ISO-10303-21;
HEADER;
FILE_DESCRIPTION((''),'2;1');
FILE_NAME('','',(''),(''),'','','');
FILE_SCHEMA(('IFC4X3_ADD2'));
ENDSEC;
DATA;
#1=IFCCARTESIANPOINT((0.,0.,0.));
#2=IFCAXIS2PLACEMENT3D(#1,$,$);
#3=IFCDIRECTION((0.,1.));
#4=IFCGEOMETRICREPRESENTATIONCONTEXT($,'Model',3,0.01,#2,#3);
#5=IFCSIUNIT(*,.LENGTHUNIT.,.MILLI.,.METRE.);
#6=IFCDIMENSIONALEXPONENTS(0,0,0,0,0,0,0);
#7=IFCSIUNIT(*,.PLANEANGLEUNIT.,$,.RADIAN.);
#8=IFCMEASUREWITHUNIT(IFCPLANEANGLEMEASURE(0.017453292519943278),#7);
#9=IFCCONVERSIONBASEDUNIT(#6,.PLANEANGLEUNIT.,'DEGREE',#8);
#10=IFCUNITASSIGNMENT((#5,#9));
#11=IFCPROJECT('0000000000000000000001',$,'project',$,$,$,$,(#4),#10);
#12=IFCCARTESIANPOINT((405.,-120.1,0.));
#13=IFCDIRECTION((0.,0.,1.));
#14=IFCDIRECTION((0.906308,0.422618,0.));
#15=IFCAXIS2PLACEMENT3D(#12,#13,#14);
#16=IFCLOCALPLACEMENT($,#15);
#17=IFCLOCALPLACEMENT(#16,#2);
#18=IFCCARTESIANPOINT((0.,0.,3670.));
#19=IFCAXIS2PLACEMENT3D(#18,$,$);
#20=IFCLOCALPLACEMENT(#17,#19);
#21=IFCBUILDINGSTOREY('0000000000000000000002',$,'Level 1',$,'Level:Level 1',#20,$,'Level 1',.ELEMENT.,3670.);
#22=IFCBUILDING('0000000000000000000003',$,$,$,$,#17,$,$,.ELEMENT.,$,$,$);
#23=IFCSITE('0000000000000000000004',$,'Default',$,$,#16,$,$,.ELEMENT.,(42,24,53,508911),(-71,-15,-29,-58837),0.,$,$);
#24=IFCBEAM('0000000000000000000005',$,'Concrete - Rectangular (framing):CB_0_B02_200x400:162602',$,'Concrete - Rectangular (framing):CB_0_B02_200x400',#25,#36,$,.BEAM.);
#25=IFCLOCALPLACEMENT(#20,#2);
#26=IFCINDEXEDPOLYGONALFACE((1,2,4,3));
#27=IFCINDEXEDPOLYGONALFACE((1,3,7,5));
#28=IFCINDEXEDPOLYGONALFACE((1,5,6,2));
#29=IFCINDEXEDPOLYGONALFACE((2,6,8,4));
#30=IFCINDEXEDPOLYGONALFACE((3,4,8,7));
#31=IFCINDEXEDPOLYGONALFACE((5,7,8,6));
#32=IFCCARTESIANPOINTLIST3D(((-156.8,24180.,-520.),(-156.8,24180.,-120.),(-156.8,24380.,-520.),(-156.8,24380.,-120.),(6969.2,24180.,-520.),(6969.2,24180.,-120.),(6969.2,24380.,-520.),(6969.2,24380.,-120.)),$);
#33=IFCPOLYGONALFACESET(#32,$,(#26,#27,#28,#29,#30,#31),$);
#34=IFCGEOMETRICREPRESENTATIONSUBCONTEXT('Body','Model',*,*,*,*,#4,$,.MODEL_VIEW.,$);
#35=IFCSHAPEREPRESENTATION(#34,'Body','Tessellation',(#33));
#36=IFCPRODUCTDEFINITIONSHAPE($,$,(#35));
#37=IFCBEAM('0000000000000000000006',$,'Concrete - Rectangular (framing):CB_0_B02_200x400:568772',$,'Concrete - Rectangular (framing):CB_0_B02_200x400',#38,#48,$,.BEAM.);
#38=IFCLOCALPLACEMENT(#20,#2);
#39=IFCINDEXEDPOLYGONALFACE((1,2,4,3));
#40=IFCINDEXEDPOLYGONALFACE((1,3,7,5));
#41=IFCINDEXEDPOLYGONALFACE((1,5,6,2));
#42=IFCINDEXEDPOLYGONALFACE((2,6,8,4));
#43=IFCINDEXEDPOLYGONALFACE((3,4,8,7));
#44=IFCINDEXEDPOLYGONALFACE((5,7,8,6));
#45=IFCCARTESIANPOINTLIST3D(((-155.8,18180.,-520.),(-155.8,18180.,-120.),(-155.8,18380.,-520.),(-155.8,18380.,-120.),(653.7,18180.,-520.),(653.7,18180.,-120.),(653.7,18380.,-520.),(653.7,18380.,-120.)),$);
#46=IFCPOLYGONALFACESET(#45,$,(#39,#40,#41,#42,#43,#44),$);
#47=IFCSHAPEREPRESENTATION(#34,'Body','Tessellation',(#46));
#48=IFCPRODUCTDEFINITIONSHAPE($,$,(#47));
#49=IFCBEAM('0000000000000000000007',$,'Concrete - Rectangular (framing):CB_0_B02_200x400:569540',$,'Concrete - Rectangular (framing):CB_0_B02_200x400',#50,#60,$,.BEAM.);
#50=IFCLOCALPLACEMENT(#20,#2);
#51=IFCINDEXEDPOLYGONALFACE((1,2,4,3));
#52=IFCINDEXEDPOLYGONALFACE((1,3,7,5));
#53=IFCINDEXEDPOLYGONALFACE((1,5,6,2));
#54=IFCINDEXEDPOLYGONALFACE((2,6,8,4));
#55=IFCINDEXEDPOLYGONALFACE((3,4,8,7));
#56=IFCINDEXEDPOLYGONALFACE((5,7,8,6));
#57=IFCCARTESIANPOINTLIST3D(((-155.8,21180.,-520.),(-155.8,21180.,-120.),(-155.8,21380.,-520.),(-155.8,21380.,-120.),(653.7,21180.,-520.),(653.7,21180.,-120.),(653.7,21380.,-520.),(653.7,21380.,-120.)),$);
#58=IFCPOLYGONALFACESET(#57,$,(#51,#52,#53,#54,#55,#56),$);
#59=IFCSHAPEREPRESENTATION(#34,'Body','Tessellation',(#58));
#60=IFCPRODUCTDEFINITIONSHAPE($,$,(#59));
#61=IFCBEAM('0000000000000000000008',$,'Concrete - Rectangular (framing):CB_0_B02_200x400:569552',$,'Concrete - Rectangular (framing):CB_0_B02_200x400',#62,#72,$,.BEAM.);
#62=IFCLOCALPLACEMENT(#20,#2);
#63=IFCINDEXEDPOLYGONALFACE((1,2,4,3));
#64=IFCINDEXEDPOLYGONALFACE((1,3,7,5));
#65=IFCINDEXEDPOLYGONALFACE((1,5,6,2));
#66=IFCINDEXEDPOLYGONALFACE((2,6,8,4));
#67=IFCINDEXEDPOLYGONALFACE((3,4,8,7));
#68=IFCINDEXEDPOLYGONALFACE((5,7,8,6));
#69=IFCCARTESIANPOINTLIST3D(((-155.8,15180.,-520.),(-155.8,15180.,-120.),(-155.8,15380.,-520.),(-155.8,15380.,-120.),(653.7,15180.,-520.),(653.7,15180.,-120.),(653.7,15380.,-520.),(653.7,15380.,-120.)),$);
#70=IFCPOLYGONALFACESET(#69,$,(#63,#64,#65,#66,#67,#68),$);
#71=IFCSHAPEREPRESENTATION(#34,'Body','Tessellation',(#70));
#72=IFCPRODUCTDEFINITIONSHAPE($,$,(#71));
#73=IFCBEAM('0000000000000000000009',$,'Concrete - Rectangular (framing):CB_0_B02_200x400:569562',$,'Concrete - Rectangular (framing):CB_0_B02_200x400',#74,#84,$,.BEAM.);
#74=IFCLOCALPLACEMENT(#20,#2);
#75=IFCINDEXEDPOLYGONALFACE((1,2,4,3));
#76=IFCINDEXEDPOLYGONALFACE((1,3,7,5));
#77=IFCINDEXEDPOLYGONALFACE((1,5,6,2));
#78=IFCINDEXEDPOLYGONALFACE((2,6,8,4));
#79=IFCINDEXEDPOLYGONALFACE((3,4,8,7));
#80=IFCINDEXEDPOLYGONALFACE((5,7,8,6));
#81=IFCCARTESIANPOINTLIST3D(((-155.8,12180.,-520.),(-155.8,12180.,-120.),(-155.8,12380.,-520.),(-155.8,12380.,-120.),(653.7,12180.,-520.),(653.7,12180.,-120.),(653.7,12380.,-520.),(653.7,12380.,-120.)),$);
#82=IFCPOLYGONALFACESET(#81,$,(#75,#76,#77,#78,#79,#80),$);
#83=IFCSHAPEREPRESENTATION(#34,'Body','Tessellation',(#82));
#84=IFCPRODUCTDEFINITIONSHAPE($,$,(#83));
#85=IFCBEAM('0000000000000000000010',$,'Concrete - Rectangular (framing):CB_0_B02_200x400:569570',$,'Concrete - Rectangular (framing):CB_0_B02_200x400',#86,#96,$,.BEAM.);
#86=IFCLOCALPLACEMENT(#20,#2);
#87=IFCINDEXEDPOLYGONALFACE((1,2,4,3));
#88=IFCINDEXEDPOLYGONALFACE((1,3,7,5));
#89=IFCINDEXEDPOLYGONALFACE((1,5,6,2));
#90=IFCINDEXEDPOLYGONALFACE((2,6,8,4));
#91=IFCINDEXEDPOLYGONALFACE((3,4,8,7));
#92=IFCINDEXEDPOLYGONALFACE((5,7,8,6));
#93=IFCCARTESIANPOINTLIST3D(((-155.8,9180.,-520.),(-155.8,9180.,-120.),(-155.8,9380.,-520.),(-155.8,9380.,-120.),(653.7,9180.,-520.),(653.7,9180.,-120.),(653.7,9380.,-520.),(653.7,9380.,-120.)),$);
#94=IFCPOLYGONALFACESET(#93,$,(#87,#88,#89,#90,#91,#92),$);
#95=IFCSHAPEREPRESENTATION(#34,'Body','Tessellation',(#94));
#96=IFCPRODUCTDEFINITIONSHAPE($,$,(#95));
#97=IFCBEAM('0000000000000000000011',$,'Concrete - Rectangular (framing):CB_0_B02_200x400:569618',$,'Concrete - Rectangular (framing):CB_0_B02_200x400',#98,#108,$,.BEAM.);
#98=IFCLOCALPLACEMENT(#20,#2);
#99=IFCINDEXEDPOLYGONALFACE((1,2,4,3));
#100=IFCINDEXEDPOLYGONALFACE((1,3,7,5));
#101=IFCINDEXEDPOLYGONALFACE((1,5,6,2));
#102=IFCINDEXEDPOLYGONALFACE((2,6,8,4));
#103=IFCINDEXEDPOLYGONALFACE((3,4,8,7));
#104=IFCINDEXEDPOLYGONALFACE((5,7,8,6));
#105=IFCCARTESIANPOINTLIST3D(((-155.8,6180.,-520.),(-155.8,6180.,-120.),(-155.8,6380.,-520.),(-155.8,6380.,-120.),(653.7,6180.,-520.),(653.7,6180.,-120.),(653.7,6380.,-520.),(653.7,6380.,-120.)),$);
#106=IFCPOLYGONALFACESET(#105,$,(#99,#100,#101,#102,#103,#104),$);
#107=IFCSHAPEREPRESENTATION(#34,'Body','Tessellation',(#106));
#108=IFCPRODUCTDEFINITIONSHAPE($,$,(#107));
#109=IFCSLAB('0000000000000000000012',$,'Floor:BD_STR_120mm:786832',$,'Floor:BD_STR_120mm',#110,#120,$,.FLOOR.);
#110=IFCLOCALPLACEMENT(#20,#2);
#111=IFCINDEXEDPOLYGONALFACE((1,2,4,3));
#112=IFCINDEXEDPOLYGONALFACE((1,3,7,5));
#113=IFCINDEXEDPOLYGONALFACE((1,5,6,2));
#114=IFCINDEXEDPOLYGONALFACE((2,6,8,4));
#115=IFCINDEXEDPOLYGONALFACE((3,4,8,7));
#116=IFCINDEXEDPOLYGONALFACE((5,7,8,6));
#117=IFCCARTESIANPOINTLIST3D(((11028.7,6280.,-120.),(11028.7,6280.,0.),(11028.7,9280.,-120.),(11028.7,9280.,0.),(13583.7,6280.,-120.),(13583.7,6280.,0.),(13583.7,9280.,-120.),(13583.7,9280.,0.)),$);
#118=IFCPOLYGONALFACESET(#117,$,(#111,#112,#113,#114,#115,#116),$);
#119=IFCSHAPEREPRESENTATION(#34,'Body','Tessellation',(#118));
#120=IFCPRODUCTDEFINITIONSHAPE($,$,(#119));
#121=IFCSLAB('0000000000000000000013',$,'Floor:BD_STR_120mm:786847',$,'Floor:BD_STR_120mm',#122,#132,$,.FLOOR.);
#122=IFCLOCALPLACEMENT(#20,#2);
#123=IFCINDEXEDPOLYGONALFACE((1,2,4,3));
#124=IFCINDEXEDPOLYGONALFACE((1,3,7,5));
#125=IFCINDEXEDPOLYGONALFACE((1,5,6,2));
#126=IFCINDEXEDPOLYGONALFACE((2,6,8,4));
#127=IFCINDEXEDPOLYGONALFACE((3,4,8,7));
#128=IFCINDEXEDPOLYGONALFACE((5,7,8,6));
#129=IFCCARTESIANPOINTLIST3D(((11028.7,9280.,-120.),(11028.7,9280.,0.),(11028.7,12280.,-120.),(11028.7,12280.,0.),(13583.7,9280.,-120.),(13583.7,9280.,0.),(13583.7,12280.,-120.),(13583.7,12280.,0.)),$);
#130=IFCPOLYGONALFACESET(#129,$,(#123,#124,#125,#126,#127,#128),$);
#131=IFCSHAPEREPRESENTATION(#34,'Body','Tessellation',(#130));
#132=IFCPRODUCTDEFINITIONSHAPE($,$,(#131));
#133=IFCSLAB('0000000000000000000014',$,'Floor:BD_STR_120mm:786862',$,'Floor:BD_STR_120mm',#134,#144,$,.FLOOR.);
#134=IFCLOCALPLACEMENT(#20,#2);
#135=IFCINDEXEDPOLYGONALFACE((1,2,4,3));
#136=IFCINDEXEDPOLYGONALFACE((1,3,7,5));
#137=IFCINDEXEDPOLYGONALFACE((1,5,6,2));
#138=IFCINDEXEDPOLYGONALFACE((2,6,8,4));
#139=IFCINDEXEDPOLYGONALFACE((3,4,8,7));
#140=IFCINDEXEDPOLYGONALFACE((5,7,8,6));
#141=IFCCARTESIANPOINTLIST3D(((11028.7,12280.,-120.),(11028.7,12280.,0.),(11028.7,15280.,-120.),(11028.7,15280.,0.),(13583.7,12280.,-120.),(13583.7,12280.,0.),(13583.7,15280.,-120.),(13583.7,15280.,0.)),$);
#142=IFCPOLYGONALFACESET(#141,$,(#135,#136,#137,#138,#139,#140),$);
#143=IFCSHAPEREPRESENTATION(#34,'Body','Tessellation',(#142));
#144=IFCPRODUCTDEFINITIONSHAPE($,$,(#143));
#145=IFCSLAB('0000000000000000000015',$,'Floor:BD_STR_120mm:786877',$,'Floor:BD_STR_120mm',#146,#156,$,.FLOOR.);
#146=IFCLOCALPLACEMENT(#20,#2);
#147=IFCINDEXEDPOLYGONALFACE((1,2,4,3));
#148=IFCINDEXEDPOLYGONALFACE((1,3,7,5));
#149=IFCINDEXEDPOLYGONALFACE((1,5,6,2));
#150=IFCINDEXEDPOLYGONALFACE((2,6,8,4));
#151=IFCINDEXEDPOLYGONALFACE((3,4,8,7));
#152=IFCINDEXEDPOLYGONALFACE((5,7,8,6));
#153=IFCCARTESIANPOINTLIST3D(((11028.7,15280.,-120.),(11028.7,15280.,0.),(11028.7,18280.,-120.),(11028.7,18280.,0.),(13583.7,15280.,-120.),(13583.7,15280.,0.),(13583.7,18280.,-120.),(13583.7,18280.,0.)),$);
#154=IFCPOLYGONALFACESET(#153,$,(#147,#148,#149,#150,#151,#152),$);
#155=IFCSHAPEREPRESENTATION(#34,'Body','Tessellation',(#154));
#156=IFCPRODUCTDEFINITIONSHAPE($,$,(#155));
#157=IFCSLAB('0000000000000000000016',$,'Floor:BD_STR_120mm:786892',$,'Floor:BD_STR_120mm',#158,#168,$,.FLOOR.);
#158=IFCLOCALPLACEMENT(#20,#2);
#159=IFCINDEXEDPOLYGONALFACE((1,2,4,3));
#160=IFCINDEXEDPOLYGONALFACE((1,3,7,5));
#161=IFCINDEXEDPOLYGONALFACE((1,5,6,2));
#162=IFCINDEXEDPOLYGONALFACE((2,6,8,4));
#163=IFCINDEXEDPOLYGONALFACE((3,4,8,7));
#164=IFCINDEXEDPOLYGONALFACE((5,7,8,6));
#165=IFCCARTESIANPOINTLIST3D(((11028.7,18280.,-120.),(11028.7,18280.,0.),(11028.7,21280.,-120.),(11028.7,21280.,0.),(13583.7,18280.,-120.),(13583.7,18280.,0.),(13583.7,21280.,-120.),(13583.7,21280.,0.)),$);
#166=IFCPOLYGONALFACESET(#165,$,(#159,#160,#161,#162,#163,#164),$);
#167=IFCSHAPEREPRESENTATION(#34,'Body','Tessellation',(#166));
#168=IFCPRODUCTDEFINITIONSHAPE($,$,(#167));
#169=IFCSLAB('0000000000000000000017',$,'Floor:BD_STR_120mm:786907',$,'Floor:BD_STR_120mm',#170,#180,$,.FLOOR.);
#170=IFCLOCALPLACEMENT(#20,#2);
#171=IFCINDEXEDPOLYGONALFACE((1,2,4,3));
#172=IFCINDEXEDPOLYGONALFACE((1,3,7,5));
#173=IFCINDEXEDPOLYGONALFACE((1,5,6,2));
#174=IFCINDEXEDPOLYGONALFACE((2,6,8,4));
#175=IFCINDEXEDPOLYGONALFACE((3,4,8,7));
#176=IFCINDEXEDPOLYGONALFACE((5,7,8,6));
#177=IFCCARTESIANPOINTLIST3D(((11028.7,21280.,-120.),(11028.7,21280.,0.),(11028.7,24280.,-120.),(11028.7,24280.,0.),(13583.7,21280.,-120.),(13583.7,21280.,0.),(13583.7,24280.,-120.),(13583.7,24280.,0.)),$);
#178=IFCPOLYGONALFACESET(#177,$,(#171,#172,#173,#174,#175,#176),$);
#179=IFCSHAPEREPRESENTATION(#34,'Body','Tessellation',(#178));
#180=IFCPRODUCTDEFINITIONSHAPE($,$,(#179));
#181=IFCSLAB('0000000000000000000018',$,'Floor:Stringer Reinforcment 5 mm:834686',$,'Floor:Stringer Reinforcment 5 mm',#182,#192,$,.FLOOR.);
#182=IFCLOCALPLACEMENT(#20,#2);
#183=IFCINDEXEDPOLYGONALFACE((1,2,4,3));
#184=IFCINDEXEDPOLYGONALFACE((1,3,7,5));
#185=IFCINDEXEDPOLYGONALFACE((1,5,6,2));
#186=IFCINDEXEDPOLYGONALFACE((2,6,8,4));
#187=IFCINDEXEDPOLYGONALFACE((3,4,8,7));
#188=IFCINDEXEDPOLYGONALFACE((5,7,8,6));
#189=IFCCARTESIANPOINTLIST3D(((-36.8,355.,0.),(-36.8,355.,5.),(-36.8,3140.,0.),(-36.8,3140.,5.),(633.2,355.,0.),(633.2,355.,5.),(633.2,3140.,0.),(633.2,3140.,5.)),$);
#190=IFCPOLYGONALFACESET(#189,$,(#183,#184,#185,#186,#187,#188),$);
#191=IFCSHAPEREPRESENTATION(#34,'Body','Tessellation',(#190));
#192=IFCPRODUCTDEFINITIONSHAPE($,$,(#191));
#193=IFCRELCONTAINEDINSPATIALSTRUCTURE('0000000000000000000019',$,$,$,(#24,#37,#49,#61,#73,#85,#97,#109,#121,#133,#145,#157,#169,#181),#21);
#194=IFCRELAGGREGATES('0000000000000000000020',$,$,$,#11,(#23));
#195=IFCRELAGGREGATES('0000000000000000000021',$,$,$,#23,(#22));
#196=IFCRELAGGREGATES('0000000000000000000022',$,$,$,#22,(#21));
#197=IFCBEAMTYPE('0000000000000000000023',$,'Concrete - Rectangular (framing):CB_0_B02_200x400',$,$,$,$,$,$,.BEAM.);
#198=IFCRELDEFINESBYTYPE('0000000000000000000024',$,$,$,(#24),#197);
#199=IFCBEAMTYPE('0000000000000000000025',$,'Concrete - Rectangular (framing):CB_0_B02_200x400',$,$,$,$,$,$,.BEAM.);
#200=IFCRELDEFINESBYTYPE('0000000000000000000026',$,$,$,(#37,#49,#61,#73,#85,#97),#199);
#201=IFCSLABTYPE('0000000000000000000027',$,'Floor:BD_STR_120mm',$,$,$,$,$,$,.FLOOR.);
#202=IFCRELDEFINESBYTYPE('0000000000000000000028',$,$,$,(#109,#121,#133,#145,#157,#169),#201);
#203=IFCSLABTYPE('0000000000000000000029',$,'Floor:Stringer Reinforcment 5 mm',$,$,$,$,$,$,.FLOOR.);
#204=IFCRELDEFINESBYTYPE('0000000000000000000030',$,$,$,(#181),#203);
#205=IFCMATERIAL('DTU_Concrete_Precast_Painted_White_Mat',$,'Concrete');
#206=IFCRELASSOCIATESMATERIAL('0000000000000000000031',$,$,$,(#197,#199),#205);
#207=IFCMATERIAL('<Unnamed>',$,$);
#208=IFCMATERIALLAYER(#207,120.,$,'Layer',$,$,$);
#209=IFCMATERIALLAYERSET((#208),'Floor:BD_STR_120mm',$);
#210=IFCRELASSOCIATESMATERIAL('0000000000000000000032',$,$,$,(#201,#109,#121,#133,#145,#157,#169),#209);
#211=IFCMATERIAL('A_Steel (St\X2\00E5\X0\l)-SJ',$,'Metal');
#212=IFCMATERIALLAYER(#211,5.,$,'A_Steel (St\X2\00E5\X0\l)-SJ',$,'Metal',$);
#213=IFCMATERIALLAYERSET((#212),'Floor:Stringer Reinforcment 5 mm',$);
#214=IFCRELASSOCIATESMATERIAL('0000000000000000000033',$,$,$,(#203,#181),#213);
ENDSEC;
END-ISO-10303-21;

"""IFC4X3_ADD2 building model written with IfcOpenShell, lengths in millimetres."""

from ifc_helpers import new_model, entity, si_unit, converted_unit, direction, frame, frame_2d, origin, origin_2d_with_axis, place, context, subcontext, project, spatial, rectangle, extrude, source, transform, mapped, material, layer, layer_set, layer_usage, material_profile, profile_set, type_object, type_shapes, element, save


model = new_model("IFC4X3_ADD2")

# Units and contexts
model_context = context("Model", 3, precision=0.01, world=origin(), true_north=direction((0.0, 1.0)))
body_context = subcontext(model_context, "Body", "Model", "MODEL_VIEW")
ifc_project = project(units=[si_unit("LENGTHUNIT", "METRE", prefix="MILLI"), converted_unit("PLANEANGLEUNIT", "DEGREE", entity("IfcPlaneAngleMeasure", 0.017453292519943278), si_unit("PLANEANGLEUNIT", "RADIAN"), dimensions=[0, 0, 0, 0, 0, 0, 0])], contexts=[model_context])

# Site, building, storey
site_placement = place(None, frame((405.0, -120.1, 0.0), z_axis=(0.0, 0.0, 1.0), x_axis=(0.906308, 0.422618, 0.0)))
site = spatial("IfcSite", under=ifc_project, at=site_placement, Name="Default", CompositionType="ELEMENT", RefLatitude=(42, 24, 53, 508911), RefLongitude=(-71, -15, -29, -58837), RefElevation=0.0)
building_placement = place(site_placement, origin())
building = spatial("IfcBuilding", under=site, at=building_placement, CompositionType="ELEMENT")
storey_placement = place(building_placement, frame((0.0, 0.0, 3670.0)))
storey = spatial("IfcBuildingStorey", under=building, at=storey_placement, Name="Level 1", ObjectType="Level:Level 1", LongName="Level 1", CompositionType="ELEMENT", Elevation=3670.0)

# Beams
ifc_material_1 = material(Name="DTU_Concrete_Precast_Painted_White_Mat", Category="Concrete")
ifc_material_profile_1 = material_profile(ifc_material_1, rectangle(XDim=7035.5, YDim=200.0, at=frame_2d((0.0, 0.0), x_axis=(1.0, 0.0))), Name="CB_0_B02_200x400")
ifc_profile_set_1 = profile_set([ifc_material_profile_1], Name="CB_0_B02_200x400")
beam_type_1 = type_object("IfcBeamType", Name="Concrete - Rectangular (framing):CB_0_B02_200x400", PredefinedType="BEAM", material=ifc_profile_set_1)
shared_shape_1 = source(origin(), body_context, "Body", "SweptSolid", [
    extrude(rectangle(XDim=7126.0, YDim=200.0, at=origin_2d_with_axis()), frame((0.0, 0.0, -200.0), z_axis=(0.0, 0.0, 1.0), x_axis=(-1.0, 0.0, 0.0)), (0.0, 0.0, 1.0), 400.0),
])
type_shapes(beam_type_1, [shared_shape_1])
beam_1_placement = place(storey_placement, frame((3406.2, 24280.0, -320.0), z_axis=(0.0, 0.0, 1.0), x_axis=(-1.0, 0.0, 0.0)))
element("IfcBeam", 1, at=beam_1_placement, inside=storey, type_object=beam_type_1, Name="Concrete - Rectangular (framing):CB_0_B02_200x400:162602", ObjectType="Concrete - Rectangular (framing):CB_0_B02_200x400", PredefinedType="BEAM", context=body_context, shape_type="MappedRepresentation", body=[
    mapped(shared_shape_1, transform((0.0, 0.0, 0.0), scale=1.0)),
])
beam_type_2 = type_object("IfcBeamType", Name="Concrete - Rectangular (framing):CB_0_B02_200x400", PredefinedType="BEAM", material=ifc_profile_set_1)
shared_shape_2 = source(origin(), body_context, "Body", "SweptSolid", [
    extrude(rectangle(XDim=200.0, YDim=809.5, at=origin_2d_with_axis()), frame((-200.0, 0.0, -200.0), z_axis=(0.0, 0.0, 1.0), x_axis=(0.0, 1.0, 0.0)), (0.0, 0.0, 1.0), 400.0),
])
type_shapes(beam_type_2, [shared_shape_2])
for number, where, z_axis, x_axis, name in (
    (2, (49.0, 18280.0, -320.0), (0.0, 0.0, 1.0), (-1.0, 0.0, 0.0), "Concrete - Rectangular (framing):CB_0_B02_200x400:568772"),
    (3, (49.0, 21280.0, -320.0), (0.0, 0.0, 1.0), (-1.0, 0.0, 0.0), "Concrete - Rectangular (framing):CB_0_B02_200x400:569540"),
    (4, (49.0, 15280.0, -320.0), (0.0, 0.0, 1.0), (-1.0, 0.0, 0.0), "Concrete - Rectangular (framing):CB_0_B02_200x400:569552"),
    (5, (49.0, 12280.0, -320.0), (0.0, 0.0, 1.0), (-1.0, 0.0, 0.0), "Concrete - Rectangular (framing):CB_0_B02_200x400:569562"),
    (6, (49.0, 9280.0, -320.0), (0.0, 0.0, 1.0), (-1.0, 0.0, 0.0), "Concrete - Rectangular (framing):CB_0_B02_200x400:569570"),
    (7, (49.0, 6280.0, -320.0), (0.0, 0.0, 1.0), (-1.0, 0.0, 0.0), "Concrete - Rectangular (framing):CB_0_B02_200x400:569618"),
):
    element("IfcBeam", number, at=place(storey_placement, frame(where, z_axis=z_axis, x_axis=x_axis)), inside=storey, type_object=beam_type_2, Name=name, ObjectType="Concrete - Rectangular (framing):CB_0_B02_200x400", PredefinedType="BEAM", context=body_context, shape_type="MappedRepresentation", body=[
        mapped(shared_shape_2, transform((0.0, 0.0, 0.0), scale=1.0)),
    ])

# Slabs
ifc_material_2 = material(Name="<Unnamed>")
ifc_layer_1 = layer(ifc_material_2, 120.0, Name="Layer")
ifc_layer_set_1 = layer_set([ifc_layer_1], Name="Floor:BD_STR_120mm")
ifc_layer_usage_1 = layer_usage(ifc_layer_set_1, "AXIS3", "POSITIVE", 0.0)
slab_type_1 = type_object("IfcSlabType", Name="Floor:BD_STR_120mm", PredefinedType="FLOOR", material=ifc_layer_set_1)
slab_1_placement = place(storey_placement, origin())
element("IfcSlab", 8, at=slab_1_placement, inside=storey, type_object=slab_type_1, material=ifc_layer_usage_1, Name="Floor:BD_STR_120mm:786832", ObjectType="Floor:BD_STR_120mm", PredefinedType="FLOOR", context=body_context, shape_type="SweptSolid", body=[
    extrude(rectangle(XDim=3000.0, YDim=2555.0, at=frame_2d((0.0, 0.0), x_axis=(1.0, 0.0))), frame((12306.2, 7780.0, 0.0), z_axis=(0.0, 0.0, -1.0), x_axis=(0.0, 1.0, 0.0)), (0.0, 0.0, 1.0), 120.0),
])
ifc_layer_usage_2 = layer_usage(ifc_layer_set_1, "AXIS3", "POSITIVE", 0.0)
slab_2_placement = place(storey_placement, origin())
element("IfcSlab", 9, at=slab_2_placement, inside=storey, type_object=slab_type_1, material=ifc_layer_usage_2, Name="Floor:BD_STR_120mm:786847", ObjectType="Floor:BD_STR_120mm", PredefinedType="FLOOR", context=body_context, shape_type="SweptSolid", body=[
    extrude(rectangle(XDim=3000.0, YDim=2555.0, at=frame_2d((0.0, 0.0), x_axis=(1.0, 0.0))), frame((12306.2, 10780.0, 0.0), z_axis=(0.0, 0.0, -1.0), x_axis=(0.0, 1.0, 0.0)), (0.0, 0.0, 1.0), 120.0),
])
ifc_layer_usage_3 = layer_usage(ifc_layer_set_1, "AXIS3", "POSITIVE", 0.0)
slab_3_placement = place(storey_placement, origin())
element("IfcSlab", 10, at=slab_3_placement, inside=storey, type_object=slab_type_1, material=ifc_layer_usage_3, Name="Floor:BD_STR_120mm:786862", ObjectType="Floor:BD_STR_120mm", PredefinedType="FLOOR", context=body_context, shape_type="SweptSolid", body=[
    extrude(rectangle(XDim=3000.0, YDim=2555.0, at=frame_2d((0.0, 0.0), x_axis=(1.0, 0.0))), frame((12306.2, 13780.0, 0.0), z_axis=(0.0, 0.0, -1.0), x_axis=(0.0, 1.0, 0.0)), (0.0, 0.0, 1.0), 120.0),
])
ifc_layer_usage_4 = layer_usage(ifc_layer_set_1, "AXIS3", "POSITIVE", 0.0)
slab_4_placement = place(storey_placement, origin())
element("IfcSlab", 11, at=slab_4_placement, inside=storey, type_object=slab_type_1, material=ifc_layer_usage_4, Name="Floor:BD_STR_120mm:786877", ObjectType="Floor:BD_STR_120mm", PredefinedType="FLOOR", context=body_context, shape_type="SweptSolid", body=[
    extrude(rectangle(XDim=3000.0, YDim=2555.0, at=frame_2d((0.0, 0.0), x_axis=(1.0, 0.0))), frame((12306.2, 16780.0, 0.0), z_axis=(0.0, 0.0, -1.0), x_axis=(0.0, 1.0, 0.0)), (0.0, 0.0, 1.0), 120.0),
])
ifc_layer_usage_5 = layer_usage(ifc_layer_set_1, "AXIS3", "POSITIVE", 0.0)
slab_5_placement = place(storey_placement, origin())
element("IfcSlab", 12, at=slab_5_placement, inside=storey, type_object=slab_type_1, material=ifc_layer_usage_5, Name="Floor:BD_STR_120mm:786892", ObjectType="Floor:BD_STR_120mm", PredefinedType="FLOOR", context=body_context, shape_type="SweptSolid", body=[
    extrude(rectangle(XDim=3000.0, YDim=2555.0, at=frame_2d((0.0, 0.0), x_axis=(1.0, 0.0))), frame((12306.2, 19780.0, 0.0), z_axis=(0.0, 0.0, -1.0), x_axis=(0.0, 1.0, 0.0)), (0.0, 0.0, 1.0), 120.0),
])
ifc_layer_usage_6 = layer_usage(ifc_layer_set_1, "AXIS3", "POSITIVE", 0.0)
slab_6_placement = place(storey_placement, origin())
element("IfcSlab", 13, at=slab_6_placement, inside=storey, type_object=slab_type_1, material=ifc_layer_usage_6, Name="Floor:BD_STR_120mm:786907", ObjectType="Floor:BD_STR_120mm", PredefinedType="FLOOR", context=body_context, shape_type="SweptSolid", body=[
    extrude(rectangle(XDim=3000.0, YDim=2555.0, at=frame_2d((0.0, 0.0), x_axis=(1.0, 0.0))), frame((12306.2, 22780.0, 0.0), z_axis=(0.0, 0.0, -1.0), x_axis=(0.0, 1.0, 0.0)), (0.0, 0.0, 1.0), 120.0),
])
ifc_material_3 = material(Name="A_Steel (Stål)-SJ", Category="Metal")
ifc_layer_2 = layer(ifc_material_3, 5.0, Name="A_Steel (Stål)-SJ", Category="Metal")
ifc_layer_set_2 = layer_set([ifc_layer_2], Name="Floor:Stringer Reinforcment 5 mm")
ifc_layer_usage_7 = layer_usage(ifc_layer_set_2, "AXIS3", "POSITIVE", 0.0)
slab_type_2 = type_object("IfcSlabType", Name="Floor:Stringer Reinforcment 5 mm", PredefinedType="FLOOR", material=ifc_layer_set_2)
slab_7_placement = place(storey_placement, origin())
element("IfcSlab", 14, at=slab_7_placement, inside=storey, type_object=slab_type_2, material=ifc_layer_usage_7, Name="Floor:Stringer Reinforcment 5 mm:834686", ObjectType="Floor:Stringer Reinforcment 5 mm", PredefinedType="FLOOR", context=body_context, shape_type="SweptSolid", body=[
    extrude(rectangle(XDim=2785.0, YDim=670.0, at=frame_2d((0.0, 0.0), x_axis=(1.0, 0.0))), frame((298.2, 1747.5, 5.0), z_axis=(0.0, 0.0, -1.0), x_axis=(0.0, 1.0, 0.0)), (0.0, 0.0, 1.0), 5.0),
])

save(model, "model.ifc")
